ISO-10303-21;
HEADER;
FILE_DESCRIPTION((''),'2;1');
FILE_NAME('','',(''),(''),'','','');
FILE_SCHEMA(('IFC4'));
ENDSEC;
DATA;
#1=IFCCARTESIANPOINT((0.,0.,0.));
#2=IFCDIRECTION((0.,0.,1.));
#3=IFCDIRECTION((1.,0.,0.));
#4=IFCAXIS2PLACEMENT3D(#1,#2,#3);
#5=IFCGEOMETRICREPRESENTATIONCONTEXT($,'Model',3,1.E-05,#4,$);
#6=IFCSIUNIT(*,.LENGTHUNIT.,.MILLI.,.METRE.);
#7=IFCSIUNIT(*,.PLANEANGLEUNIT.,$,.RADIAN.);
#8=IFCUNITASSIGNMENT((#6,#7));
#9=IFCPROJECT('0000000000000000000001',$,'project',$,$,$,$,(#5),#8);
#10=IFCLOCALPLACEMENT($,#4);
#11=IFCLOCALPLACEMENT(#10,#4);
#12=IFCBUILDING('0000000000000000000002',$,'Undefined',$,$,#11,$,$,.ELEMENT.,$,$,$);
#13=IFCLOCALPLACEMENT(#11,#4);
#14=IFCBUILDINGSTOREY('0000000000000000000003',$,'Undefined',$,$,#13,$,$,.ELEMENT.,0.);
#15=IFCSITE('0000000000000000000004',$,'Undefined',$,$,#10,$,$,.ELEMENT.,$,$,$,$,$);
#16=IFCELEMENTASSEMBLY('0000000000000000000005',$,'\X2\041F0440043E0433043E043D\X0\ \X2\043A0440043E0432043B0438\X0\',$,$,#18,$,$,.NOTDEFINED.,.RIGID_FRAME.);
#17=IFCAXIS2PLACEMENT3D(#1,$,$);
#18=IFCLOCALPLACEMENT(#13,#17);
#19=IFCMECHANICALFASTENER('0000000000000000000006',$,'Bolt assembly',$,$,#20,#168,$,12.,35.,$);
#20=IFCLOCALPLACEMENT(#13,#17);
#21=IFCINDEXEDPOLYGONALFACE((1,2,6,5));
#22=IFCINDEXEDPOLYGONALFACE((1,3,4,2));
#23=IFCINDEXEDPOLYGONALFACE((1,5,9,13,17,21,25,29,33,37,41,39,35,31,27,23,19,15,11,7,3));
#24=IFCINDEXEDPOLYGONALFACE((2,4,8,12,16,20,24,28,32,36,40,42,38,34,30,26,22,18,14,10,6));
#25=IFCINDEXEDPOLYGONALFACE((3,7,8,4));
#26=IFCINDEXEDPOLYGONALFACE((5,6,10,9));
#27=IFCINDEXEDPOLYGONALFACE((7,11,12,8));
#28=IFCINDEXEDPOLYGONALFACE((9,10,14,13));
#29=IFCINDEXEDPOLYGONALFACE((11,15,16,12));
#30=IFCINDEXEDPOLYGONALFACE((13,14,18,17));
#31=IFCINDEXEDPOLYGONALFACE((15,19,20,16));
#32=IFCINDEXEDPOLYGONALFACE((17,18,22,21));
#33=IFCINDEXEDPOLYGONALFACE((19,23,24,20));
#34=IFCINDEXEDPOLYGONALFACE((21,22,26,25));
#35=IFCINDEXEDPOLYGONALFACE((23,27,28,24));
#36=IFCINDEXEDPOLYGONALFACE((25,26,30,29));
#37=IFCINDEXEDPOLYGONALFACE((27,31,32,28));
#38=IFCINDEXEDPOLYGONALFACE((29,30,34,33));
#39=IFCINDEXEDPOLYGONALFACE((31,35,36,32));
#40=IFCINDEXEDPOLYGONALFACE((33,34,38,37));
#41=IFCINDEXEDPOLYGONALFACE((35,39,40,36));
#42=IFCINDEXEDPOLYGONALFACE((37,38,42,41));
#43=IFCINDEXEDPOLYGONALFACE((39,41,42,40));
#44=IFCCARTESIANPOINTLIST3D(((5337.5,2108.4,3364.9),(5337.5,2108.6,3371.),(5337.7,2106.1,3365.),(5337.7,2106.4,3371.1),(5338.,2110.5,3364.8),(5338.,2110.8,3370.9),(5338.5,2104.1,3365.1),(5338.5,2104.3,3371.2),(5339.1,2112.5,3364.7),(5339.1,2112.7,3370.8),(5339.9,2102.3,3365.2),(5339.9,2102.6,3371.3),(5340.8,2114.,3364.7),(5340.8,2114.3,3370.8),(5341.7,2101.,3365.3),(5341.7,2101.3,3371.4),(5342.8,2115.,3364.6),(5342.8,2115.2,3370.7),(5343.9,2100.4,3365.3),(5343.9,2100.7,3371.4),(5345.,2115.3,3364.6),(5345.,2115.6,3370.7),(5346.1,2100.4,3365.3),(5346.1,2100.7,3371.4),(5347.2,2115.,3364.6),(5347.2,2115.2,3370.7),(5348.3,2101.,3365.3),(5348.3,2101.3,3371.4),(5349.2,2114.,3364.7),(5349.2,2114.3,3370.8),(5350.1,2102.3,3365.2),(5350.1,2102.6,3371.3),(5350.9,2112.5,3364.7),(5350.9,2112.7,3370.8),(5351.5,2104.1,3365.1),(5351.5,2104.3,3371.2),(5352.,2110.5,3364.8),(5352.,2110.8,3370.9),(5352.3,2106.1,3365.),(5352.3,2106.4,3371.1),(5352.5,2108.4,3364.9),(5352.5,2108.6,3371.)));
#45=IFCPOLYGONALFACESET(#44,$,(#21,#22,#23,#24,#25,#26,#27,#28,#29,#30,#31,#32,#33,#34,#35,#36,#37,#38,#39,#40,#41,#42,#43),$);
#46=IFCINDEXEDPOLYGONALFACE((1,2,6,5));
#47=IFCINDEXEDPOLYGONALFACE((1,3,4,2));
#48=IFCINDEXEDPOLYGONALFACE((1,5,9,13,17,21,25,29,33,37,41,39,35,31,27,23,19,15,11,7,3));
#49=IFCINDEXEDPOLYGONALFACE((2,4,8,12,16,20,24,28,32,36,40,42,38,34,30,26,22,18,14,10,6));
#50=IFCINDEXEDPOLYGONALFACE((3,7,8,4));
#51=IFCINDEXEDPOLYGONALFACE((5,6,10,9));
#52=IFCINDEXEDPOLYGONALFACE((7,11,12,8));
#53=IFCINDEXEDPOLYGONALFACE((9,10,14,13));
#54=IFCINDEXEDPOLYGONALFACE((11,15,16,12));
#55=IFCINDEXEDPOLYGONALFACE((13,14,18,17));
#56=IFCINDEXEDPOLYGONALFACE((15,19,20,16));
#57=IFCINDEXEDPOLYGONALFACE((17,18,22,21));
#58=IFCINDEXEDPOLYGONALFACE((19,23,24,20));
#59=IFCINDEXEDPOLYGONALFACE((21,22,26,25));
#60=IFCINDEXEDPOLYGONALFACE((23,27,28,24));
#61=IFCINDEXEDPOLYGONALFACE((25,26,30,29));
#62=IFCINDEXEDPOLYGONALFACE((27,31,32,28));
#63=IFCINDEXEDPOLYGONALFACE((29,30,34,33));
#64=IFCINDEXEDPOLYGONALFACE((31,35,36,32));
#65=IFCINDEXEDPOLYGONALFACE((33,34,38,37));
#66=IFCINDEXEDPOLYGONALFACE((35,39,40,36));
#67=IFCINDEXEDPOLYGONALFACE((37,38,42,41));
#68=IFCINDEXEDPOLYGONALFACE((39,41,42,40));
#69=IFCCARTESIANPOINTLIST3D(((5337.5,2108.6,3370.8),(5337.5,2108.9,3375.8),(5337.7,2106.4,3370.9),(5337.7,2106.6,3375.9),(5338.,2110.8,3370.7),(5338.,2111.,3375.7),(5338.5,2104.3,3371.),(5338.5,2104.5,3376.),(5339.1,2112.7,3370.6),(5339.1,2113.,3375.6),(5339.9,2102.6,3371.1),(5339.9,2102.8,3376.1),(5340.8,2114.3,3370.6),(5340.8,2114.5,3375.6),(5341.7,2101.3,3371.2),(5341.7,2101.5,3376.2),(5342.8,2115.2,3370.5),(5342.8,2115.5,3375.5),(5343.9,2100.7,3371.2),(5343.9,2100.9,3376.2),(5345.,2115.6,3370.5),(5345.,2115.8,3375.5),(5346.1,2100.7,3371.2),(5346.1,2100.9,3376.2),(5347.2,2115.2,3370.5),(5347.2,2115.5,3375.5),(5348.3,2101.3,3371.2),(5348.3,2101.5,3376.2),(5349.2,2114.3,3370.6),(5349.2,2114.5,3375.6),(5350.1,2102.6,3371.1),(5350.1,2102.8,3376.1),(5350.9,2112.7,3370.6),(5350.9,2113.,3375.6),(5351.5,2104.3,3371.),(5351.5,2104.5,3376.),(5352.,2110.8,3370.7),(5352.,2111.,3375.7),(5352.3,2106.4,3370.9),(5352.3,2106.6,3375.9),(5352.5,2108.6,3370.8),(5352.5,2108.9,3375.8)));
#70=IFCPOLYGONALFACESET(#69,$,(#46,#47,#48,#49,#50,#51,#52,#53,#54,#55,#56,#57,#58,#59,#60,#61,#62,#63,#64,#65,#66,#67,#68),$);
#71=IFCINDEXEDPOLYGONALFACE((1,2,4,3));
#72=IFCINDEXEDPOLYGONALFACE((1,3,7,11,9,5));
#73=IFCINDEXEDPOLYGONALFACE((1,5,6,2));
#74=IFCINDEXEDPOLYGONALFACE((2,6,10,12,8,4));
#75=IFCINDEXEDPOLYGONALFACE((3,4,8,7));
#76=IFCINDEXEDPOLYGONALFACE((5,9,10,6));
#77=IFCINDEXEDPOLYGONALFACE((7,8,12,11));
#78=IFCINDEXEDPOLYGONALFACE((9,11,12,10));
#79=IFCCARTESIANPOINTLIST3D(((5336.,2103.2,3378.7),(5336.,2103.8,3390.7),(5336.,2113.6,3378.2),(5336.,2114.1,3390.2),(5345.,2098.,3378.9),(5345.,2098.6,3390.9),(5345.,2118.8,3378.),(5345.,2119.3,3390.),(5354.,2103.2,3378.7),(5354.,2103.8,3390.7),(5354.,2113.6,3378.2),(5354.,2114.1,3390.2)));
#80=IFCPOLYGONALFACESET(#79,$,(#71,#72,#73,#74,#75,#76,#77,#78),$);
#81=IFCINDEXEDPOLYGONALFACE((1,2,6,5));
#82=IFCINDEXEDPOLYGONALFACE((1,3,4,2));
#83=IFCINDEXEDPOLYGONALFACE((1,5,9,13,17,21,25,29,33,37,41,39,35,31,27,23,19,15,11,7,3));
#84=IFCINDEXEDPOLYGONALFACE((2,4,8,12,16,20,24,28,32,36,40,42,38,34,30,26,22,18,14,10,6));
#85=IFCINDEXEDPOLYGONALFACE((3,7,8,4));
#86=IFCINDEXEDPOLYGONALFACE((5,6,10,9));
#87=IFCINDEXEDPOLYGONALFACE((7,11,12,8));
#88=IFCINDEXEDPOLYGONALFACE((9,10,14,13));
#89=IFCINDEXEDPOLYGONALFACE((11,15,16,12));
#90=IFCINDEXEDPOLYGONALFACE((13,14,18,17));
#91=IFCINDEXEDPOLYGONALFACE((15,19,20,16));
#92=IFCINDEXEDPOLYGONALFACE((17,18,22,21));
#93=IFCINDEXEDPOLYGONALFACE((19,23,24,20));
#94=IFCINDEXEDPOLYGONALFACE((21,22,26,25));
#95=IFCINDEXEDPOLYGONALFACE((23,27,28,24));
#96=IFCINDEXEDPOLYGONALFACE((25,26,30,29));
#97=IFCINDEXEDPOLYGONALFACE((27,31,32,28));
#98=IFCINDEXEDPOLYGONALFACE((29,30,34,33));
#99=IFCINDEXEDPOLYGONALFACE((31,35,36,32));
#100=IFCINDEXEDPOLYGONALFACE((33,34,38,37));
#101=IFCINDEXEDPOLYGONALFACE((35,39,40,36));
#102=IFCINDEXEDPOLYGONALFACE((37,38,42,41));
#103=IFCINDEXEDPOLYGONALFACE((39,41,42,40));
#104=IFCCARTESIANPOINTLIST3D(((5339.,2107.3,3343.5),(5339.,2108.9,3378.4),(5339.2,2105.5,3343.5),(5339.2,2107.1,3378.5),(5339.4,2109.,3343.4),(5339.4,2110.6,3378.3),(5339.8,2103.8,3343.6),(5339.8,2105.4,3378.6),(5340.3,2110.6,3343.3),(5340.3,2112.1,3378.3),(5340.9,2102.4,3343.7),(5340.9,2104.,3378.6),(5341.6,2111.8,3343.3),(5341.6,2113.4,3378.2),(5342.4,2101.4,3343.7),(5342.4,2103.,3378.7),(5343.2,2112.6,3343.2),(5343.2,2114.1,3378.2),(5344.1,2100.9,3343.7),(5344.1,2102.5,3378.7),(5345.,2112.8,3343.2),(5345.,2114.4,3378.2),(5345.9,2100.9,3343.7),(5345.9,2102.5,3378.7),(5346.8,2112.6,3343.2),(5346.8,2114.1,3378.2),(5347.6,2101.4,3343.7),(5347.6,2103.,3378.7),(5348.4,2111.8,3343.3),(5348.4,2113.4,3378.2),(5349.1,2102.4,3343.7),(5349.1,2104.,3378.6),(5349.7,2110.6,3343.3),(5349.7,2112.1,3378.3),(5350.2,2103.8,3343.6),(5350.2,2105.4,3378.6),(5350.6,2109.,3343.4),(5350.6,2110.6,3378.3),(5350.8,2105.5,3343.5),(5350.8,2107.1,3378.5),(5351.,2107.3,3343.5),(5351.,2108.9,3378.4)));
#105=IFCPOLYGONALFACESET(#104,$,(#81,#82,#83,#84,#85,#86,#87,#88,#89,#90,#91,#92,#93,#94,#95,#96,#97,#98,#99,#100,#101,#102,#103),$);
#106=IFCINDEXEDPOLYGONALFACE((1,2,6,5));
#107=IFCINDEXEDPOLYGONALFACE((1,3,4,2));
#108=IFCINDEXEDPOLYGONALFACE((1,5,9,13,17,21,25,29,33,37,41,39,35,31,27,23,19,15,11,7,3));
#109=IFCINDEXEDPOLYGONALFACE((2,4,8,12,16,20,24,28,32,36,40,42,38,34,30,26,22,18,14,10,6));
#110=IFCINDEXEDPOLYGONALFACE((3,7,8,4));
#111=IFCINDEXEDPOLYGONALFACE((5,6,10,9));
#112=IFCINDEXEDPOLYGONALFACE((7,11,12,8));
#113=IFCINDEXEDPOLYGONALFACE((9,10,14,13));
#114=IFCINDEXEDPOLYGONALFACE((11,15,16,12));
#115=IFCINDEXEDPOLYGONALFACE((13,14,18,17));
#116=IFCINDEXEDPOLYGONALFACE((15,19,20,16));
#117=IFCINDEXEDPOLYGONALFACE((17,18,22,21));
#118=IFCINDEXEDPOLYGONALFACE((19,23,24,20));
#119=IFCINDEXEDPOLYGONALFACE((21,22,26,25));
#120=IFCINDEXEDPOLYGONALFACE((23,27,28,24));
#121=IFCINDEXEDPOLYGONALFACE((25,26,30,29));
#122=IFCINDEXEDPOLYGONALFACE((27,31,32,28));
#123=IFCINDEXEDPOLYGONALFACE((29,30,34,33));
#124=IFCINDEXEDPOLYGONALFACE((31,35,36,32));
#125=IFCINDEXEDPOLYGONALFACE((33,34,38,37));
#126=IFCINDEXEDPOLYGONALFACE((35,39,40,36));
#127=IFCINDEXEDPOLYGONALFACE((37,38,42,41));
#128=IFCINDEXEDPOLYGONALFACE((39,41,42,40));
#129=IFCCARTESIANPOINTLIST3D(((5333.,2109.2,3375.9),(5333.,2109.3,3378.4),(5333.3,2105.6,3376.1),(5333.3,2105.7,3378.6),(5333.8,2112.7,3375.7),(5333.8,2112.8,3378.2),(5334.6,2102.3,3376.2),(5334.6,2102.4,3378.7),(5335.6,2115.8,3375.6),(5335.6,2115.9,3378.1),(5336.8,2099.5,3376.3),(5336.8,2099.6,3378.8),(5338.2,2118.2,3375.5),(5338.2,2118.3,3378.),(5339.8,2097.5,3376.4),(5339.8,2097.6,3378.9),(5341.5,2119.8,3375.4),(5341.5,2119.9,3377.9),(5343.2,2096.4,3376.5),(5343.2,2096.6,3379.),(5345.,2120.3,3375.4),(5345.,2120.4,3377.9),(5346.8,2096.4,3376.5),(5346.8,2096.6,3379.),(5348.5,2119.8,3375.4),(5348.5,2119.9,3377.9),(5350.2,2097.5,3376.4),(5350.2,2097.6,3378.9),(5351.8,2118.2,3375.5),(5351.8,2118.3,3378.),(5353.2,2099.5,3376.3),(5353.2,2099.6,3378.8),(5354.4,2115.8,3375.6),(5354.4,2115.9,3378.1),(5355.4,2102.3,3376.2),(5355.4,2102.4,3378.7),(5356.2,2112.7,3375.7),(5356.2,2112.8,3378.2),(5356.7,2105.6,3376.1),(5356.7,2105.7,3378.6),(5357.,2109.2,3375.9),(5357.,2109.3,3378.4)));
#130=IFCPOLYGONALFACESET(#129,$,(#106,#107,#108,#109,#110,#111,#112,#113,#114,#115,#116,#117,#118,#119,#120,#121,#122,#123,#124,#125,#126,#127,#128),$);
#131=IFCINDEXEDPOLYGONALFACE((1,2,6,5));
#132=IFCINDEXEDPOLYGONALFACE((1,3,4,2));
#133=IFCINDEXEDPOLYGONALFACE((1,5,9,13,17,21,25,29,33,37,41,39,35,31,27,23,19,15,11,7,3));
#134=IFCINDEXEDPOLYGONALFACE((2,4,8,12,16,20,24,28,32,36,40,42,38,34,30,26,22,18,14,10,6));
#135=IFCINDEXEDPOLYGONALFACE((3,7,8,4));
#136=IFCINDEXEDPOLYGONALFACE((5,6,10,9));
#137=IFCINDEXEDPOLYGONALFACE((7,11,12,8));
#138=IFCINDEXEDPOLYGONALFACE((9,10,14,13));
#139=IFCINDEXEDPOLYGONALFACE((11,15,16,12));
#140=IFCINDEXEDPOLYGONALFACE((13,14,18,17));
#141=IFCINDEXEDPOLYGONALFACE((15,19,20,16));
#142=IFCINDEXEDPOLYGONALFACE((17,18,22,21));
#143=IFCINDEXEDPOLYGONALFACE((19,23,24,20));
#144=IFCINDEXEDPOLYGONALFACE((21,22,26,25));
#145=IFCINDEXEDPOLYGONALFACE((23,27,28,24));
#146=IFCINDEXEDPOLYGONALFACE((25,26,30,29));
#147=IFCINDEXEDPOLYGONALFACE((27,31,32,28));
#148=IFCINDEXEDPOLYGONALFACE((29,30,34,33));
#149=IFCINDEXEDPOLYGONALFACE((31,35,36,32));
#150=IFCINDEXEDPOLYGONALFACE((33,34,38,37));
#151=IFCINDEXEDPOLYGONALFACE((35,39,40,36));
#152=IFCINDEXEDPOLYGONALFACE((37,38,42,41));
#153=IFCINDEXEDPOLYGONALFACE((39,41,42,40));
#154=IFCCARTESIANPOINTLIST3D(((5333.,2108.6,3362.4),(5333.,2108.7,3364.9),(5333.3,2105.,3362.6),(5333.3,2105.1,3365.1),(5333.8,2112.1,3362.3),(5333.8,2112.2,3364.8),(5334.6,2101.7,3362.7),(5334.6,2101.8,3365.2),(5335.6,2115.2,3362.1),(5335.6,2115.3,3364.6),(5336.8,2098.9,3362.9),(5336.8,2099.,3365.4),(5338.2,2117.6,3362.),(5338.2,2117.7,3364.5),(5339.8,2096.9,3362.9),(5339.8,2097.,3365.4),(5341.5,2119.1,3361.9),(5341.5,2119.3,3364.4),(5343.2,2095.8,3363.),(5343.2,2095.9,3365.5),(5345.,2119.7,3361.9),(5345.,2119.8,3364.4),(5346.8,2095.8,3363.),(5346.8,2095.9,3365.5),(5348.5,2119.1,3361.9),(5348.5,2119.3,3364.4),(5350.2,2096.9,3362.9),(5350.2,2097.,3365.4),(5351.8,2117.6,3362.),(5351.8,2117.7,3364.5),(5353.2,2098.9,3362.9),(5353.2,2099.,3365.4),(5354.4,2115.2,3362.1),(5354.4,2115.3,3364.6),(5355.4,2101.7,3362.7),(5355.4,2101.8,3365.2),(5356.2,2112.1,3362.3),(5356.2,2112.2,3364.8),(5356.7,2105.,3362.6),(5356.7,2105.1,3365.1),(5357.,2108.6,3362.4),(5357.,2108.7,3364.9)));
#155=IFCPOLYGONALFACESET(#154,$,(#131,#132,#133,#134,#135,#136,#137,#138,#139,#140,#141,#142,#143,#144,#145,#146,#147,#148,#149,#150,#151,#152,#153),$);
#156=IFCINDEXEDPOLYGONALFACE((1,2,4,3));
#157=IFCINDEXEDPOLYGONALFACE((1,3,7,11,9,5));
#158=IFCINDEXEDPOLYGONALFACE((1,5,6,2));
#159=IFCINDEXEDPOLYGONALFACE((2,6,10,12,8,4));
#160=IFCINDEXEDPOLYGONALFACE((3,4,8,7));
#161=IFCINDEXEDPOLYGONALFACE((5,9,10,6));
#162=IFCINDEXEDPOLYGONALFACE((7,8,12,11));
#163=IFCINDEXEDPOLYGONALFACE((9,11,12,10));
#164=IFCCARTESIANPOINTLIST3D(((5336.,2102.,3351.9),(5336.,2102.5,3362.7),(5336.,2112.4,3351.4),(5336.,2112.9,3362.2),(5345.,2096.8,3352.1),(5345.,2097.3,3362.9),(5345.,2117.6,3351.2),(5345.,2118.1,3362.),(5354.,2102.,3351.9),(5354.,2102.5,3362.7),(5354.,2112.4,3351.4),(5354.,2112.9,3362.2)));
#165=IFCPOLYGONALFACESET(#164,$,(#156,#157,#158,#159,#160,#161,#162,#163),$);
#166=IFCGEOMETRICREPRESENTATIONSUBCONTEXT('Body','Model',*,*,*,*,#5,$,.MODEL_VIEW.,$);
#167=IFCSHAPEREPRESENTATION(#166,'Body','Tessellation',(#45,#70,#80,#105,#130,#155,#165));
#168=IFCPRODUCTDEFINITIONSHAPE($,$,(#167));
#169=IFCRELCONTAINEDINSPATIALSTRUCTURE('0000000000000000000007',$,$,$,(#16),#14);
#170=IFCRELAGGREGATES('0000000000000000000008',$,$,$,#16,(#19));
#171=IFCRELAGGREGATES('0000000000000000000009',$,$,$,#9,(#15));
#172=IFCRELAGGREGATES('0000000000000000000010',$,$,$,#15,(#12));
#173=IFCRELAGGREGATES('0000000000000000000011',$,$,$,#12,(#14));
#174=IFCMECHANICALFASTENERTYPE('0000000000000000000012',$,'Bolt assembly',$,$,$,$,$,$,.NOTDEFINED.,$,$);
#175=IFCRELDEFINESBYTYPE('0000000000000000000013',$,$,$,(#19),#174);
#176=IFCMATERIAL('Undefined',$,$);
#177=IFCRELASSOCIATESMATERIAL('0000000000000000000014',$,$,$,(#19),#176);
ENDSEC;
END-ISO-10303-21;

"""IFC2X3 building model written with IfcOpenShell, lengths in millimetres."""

from ifc_helpers import new_model, si_unit, frame, origin_with_axes, origin_2d_with_axis, place, context, subcontext, project, spatial, polyline, circle, outline, extrude, source, transform, mapped, material, type_object, element, aggregate, save


model = new_model("IFC2X3")

# Units and contexts
model_context = context("Model", 3, precision=1e-05, world=origin_with_axes())
body_context = subcontext(model_context, "Body", "Model", "MODEL_VIEW")
ifc_project = project(units=[si_unit("LENGTHUNIT", "METRE", prefix="MILLI"), si_unit("PLANEANGLEUNIT", "RADIAN")], contexts=[model_context])

# Site, building, storey
site_placement = place(None, origin_with_axes())
site = spatial("IfcSite", under=ifc_project, at=site_placement, Name="Undefined", CompositionType="ELEMENT")
building_placement = place(site_placement, origin_with_axes())
building = spatial("IfcBuilding", under=site, at=building_placement, Name="Undefined", CompositionType="ELEMENT")
storey_placement = place(building_placement, origin_with_axes())
storey = spatial("IfcBuildingStorey", under=building, at=storey_placement, Name="Undefined", CompositionType="ELEMENT", Elevation=0.0)

# Element assembly
assembly_1_placement = place(storey_placement, origin_with_axes())
assembly_1 = element("IfcElementAssembly", 1, at=assembly_1_placement, inside=storey, Name="Прогон кровли", AssemblyPlace="NOTDEFINED", PredefinedType="RIGID_FRAME")

# Mechanical fastener
ifc_material_1 = material(Name="Undefined")
mechanical_fastener_type = type_object("IfcMechanicalFastenerType", Name="Bolt assembly")
shared_shape_1 = source(origin_with_axes(), body_context, "Body", "SweptSolid", [
    extrude(circle(Radius=7.5, at=origin_2d_with_axis()), frame((0.0, -0.1, 0.0), z_axis=(0.0, 1.0, 0.0), x_axis=(1.0, 0.0, 0.0)), (0.0, 0.0, 1.0), 6.1),
    extrude(circle(Radius=7.5, at=origin_2d_with_axis()), frame((0.0, -4.9, 0.0), z_axis=(0.0, 1.0, 0.0), x_axis=(1.0, 0.0, 0.0)), (0.0, 0.0, 1.0), 5.0),
    extrude(outline(polyline([(10.4, 0.0), (5.2, 9.0), (-5.2, 9.0), (-10.4, 0.0), (-5.2, -9.0), (5.2, -9.0), (10.4, 0.0)])), frame((0.0, -19.5, 0.0), z_axis=(0.0, 1.0, 0.0), x_axis=(1.0, 0.0, 0.0)), (0.0, 0.0, 1.0), 12.0),
    extrude(circle(Radius=6.0, at=origin_2d_with_axis()), frame((0.0, -7.5, 0.0), z_axis=(0.0, 1.0, 0.0), x_axis=(1.0, 0.0, 0.0)), (0.0, 0.0, 1.0), 35.0),
    extrude(circle(Radius=12.0, at=origin_2d_with_axis()), frame((0.0, -7.5, 0.0), z_axis=(0.0, 1.0, 0.0), x_axis=(1.0, 0.0, 0.0)), (0.0, 0.0, 1.0), 2.5),
    extrude(circle(Radius=12.0, at=origin_2d_with_axis()), frame((0.0, 6.0, 0.0), z_axis=(0.0, 1.0, 0.0), x_axis=(1.0, 0.0, 0.0)), (0.0, 0.0, 1.0), 2.5),
    extrude(outline(polyline([(10.4, 0.0), (5.2, 9.0), (-5.2, 9.0), (-10.4, 0.0), (-5.2, -9.0), (5.2, -9.0), (10.4, 0.0)])), frame((0.0, 8.5, 0.0), z_axis=(0.0, 1.0, 0.0), x_axis=(1.0, 0.0, 0.0)), (0.0, 0.0, 1.0), 10.8),
])
mechanical_fastener_1_placement = place(assembly_1_placement, frame((5345.0, 2108.1, 3370.9), z_axis=(-1.0, 0.0, 0.0), x_axis=(0.0, 0.998969, -0.045408)))
mechanical_fastener_1 = element("IfcMechanicalFastener", 2, at=mechanical_fastener_1_placement, type_object=mechanical_fastener_type, material=ifc_material_1, Name="Bolt assembly", NominalDiameter=12.0, NominalLength=35.0, context=body_context, shape_type="MappedRepresentation", body=[
    mapped(shared_shape_1, transform((0.0, 0.0, 0.0))),
])
aggregate(assembly_1, [mechanical_fastener_1])

save(model, "model.ifc")
